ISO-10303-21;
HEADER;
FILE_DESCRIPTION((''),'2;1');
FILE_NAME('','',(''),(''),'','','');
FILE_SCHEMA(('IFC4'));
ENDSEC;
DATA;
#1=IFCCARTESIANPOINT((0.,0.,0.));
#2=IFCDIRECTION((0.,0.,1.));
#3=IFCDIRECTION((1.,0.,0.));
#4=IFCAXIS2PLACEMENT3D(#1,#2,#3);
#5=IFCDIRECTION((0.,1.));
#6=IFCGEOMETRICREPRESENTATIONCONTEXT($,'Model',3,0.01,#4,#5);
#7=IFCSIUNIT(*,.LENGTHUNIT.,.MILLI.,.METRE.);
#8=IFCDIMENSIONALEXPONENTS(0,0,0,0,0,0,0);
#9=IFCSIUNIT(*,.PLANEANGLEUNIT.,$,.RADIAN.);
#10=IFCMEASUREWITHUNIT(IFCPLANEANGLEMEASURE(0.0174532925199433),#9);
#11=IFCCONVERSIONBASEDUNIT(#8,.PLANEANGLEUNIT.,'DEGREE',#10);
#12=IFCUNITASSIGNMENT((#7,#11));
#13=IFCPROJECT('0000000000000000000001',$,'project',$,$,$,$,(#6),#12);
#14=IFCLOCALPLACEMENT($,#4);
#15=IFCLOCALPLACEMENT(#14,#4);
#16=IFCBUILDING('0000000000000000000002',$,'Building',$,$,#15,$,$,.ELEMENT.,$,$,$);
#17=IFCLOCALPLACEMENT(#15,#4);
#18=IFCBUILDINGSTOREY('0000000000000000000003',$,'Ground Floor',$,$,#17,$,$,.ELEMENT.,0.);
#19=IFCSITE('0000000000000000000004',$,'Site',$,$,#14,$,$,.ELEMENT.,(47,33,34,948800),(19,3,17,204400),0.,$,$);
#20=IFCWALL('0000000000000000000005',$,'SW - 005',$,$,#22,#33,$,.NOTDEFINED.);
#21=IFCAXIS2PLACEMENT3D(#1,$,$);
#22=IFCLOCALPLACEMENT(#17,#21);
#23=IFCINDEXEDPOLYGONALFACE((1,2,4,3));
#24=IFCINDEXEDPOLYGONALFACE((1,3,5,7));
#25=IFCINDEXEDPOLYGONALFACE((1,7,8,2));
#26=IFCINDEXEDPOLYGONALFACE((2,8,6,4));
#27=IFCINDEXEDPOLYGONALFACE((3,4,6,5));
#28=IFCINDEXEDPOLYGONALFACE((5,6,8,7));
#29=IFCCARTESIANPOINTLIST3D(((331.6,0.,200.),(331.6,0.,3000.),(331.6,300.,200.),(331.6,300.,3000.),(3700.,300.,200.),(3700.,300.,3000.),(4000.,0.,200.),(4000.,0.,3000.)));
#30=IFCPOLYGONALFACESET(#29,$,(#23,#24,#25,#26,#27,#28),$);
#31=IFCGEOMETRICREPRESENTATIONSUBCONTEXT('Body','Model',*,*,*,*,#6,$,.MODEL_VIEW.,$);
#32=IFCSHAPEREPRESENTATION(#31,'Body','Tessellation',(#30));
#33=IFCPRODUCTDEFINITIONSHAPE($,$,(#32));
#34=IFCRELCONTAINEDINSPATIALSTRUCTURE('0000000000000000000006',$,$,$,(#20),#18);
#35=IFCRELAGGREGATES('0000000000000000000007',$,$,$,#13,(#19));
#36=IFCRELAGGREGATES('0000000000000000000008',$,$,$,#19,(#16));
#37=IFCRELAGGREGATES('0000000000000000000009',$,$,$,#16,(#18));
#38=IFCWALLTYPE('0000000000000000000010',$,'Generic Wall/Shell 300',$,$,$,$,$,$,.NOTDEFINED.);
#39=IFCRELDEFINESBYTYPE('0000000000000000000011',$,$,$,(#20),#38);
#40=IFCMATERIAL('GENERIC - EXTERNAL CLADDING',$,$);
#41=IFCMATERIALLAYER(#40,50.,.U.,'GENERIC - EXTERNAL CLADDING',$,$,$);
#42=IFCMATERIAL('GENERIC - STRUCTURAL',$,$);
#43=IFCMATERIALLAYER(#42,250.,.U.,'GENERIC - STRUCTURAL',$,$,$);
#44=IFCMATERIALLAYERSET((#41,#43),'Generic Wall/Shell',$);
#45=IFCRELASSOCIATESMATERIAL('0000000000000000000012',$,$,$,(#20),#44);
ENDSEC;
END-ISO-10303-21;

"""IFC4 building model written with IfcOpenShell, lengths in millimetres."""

from ifc_helpers import new_model, entity, si_unit, converted_unit, direction, frame, origin_with_axes, place, context, subcontext, project, spatial, line, indexed_curve, outline, extrude, material, layer, layer_set, layer_usage, type_object, element, save


model = new_model("IFC4")

# Units and contexts
model_context = context("Model", 3, precision=0.01, world=origin_with_axes(), true_north=direction((0.0, 1.0)))
body_context = subcontext(model_context, "Body", "Model", "MODEL_VIEW")
ifc_project = project(units=[si_unit("LENGTHUNIT", "METRE", prefix="MILLI"), converted_unit("PLANEANGLEUNIT", "DEGREE", entity("IfcPlaneAngleMeasure", 0.0174532925199433), si_unit("PLANEANGLEUNIT", "RADIAN"), dimensions=[0, 0, 0, 0, 0, 0, 0])], contexts=[model_context])

# Site, building, storey
site_placement = place(None, origin_with_axes())
site = spatial("IfcSite", under=ifc_project, at=site_placement, Name="Site", CompositionType="ELEMENT", RefLatitude=(47, 33, 34, 948800), RefLongitude=(19, 3, 17, 204400), RefElevation=0.0)
building_placement = place(site_placement, origin_with_axes())
building = spatial("IfcBuilding", under=site, at=building_placement, Name="Building", CompositionType="ELEMENT")
storey_placement = place(building_placement, origin_with_axes())
storey = spatial("IfcBuildingStorey", under=building, at=storey_placement, Name="Ground Floor", CompositionType="ELEMENT", Elevation=0.0)

# Wall
ifc_material_1 = material(Name="GENERIC - EXTERNAL CLADDING")
ifc_layer_1 = layer(ifc_material_1, 50.0, ventilated="UNKNOWN", Name="GENERIC - EXTERNAL CLADDING")
ifc_material_2 = material(Name="GENERIC - STRUCTURAL")
ifc_layer_2 = layer(ifc_material_2, 250.0, ventilated="UNKNOWN", Name="GENERIC - STRUCTURAL")
ifc_layer_set_1 = layer_set([ifc_layer_1, ifc_layer_2], Name="Generic Wall/Shell")
ifc_layer_usage_1 = layer_usage(ifc_layer_set_1, "AXIS2", "POSITIVE", -300.0)
wall_type = type_object("IfcWallType", Name="Generic Wall/Shell 300", PredefinedType="NOTDEFINED")
wall_placement = place(storey_placement, frame((4000.0, 0.0, 200.0), z_axis=(0.0, 0.0, 1.0), x_axis=(-1.0, 0.0, 0.0)))
element("IfcWall", 1, at=wall_placement, inside=storey, type_object=wall_type, material=ifc_layer_usage_1, Name="SW - 005", PredefinedType="NOTDEFINED", context=body_context, shape_type="SweptSolid", body=[
    extrude(outline(indexed_curve([(300.0, -300.0), (3668.4, -300.0), (3668.4, 0.0), (0.0, 0.0)], segments=[line(1, 2, 3, 4, 1)])), origin_with_axes(), (0.0, 0.0, 1.0), 2800.0),
])

save(model, "model.ifc")
